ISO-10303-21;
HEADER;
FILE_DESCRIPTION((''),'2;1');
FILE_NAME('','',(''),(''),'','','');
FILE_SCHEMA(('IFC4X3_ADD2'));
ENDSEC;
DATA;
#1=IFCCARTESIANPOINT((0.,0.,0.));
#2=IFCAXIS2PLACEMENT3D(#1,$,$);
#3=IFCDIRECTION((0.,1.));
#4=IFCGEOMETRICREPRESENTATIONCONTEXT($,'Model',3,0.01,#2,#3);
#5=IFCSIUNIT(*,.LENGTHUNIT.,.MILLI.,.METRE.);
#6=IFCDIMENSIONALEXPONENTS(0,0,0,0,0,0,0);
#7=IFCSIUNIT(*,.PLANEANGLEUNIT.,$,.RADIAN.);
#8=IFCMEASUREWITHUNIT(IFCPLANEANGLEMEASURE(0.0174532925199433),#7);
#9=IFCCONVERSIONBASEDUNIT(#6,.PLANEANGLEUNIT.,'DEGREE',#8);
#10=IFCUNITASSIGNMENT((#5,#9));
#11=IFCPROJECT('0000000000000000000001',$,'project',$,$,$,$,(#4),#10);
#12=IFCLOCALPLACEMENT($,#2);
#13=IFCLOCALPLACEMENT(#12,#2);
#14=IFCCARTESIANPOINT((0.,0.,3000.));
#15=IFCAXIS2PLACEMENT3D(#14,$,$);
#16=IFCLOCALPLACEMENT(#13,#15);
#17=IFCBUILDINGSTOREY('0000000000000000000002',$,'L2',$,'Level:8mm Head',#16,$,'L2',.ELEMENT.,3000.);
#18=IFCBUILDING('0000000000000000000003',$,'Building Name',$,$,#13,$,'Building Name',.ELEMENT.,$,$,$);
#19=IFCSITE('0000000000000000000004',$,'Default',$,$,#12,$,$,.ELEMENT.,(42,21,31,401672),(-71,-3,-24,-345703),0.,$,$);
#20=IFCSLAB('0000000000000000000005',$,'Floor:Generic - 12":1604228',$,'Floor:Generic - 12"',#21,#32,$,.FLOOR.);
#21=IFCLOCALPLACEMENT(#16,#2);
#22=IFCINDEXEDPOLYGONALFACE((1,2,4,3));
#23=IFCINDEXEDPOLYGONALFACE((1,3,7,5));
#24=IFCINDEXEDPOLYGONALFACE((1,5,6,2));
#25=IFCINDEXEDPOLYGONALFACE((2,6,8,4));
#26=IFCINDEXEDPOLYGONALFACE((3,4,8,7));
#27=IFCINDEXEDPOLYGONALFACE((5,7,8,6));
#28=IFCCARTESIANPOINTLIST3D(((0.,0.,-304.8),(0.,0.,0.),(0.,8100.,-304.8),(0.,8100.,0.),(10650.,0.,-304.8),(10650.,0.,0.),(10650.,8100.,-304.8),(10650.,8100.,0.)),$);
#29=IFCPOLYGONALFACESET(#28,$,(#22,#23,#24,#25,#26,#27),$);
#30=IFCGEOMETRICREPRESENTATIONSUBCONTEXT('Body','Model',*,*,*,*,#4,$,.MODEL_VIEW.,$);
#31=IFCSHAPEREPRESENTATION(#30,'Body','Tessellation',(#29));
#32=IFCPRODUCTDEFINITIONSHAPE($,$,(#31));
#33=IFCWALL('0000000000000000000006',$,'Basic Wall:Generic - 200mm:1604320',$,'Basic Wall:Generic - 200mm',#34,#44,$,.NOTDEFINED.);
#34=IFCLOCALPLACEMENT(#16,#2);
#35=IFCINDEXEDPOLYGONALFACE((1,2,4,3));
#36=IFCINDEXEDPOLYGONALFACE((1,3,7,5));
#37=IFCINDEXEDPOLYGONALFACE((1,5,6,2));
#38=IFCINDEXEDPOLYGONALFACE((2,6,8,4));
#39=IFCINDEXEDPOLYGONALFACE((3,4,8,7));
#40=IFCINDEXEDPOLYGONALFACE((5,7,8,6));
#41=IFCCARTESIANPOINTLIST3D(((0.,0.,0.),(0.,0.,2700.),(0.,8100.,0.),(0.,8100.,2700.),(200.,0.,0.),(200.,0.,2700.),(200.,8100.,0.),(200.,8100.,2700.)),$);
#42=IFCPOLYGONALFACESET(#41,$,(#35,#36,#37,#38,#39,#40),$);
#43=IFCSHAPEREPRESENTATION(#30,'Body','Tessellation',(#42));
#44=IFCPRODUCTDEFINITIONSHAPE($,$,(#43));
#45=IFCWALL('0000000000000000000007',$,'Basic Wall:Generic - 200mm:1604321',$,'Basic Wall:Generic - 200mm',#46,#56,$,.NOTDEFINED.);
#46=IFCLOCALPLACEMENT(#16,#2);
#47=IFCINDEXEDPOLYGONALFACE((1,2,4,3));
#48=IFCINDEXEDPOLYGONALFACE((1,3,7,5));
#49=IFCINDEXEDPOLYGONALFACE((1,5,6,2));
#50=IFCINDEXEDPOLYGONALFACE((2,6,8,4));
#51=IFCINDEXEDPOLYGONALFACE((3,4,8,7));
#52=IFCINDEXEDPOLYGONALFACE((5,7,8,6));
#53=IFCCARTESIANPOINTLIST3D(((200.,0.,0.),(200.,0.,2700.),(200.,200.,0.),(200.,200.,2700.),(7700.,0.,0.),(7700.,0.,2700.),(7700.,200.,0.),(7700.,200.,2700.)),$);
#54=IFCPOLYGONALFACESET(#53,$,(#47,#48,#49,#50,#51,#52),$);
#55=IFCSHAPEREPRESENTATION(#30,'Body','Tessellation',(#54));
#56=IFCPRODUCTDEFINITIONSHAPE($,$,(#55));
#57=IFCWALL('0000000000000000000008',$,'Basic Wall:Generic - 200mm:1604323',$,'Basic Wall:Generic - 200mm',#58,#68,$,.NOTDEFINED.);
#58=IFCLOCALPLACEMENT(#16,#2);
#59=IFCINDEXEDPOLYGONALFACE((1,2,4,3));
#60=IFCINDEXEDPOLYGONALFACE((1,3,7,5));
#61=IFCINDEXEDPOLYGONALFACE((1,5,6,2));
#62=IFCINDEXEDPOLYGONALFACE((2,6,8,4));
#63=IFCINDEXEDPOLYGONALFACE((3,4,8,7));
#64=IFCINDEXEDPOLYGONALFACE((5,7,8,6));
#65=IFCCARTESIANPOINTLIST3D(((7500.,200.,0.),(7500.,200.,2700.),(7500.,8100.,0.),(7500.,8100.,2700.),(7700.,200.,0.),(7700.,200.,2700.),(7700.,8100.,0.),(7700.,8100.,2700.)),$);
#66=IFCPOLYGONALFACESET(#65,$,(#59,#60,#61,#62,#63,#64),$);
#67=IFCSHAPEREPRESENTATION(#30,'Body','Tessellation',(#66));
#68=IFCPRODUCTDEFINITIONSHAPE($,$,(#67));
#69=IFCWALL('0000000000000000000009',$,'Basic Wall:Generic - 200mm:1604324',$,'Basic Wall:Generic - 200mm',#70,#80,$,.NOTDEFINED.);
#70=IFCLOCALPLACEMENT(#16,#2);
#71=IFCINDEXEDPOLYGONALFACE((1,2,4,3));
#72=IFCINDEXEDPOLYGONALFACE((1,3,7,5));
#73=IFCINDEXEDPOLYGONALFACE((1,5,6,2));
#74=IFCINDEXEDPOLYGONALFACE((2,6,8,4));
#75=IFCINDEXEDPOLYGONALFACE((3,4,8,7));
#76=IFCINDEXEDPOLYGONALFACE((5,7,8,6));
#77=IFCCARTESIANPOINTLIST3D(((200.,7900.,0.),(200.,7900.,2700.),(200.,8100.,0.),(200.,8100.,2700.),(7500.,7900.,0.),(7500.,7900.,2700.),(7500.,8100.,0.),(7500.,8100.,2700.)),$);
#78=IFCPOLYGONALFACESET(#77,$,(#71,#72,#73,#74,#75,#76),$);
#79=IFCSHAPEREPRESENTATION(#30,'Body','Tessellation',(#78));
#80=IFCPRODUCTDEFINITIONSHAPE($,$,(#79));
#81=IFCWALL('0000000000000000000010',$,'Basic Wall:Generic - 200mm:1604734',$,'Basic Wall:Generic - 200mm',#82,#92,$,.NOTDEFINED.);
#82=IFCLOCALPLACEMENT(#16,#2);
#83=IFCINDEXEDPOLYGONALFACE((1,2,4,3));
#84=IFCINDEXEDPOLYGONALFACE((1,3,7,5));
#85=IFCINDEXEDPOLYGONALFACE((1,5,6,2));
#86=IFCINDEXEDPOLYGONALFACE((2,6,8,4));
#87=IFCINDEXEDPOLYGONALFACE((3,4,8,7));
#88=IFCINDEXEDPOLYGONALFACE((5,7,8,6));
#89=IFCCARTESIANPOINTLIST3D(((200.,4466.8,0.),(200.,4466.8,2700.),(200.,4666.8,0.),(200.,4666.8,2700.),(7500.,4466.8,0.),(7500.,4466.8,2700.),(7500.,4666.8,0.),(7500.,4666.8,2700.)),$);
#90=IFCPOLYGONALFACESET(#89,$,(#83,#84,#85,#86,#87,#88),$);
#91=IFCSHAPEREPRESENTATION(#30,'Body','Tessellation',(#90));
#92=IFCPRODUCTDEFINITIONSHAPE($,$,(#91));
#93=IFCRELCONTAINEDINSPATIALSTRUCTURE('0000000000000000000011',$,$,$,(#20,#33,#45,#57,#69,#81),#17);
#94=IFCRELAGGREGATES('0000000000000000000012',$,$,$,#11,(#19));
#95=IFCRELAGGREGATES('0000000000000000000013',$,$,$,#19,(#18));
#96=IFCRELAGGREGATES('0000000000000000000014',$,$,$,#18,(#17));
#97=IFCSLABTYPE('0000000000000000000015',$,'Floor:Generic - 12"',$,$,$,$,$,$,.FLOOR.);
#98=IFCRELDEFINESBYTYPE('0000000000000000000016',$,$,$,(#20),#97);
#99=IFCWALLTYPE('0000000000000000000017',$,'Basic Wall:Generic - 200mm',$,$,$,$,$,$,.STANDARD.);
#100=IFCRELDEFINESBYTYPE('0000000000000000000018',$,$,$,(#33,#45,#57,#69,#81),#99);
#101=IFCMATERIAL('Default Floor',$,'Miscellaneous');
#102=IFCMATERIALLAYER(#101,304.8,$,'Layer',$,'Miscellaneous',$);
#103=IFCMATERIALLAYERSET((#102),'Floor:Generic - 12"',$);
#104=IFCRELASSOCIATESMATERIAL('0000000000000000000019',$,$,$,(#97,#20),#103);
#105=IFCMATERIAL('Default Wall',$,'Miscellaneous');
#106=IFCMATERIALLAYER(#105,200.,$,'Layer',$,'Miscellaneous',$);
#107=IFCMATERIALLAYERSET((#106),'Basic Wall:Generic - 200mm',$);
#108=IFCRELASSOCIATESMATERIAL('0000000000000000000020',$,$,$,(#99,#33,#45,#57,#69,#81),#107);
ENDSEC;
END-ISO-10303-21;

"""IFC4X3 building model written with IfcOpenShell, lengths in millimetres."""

from ifc_helpers import new_model, entity, si_unit, converted_unit, direction, frame, frame_2d, origin, origin_2d_with_axis, place, context, subcontext, project, spatial, rectangle, extrude, material, layer, layer_set, layer_usage, type_object, element, save


model = new_model("IFC4X3")

# Units and contexts
model_context = context("Model", 3, precision=0.01, world=origin(), true_north=direction((0.0, 1.0)))
body_context = subcontext(model_context, "Body", "Model", "MODEL_VIEW")
ifc_project = project(units=[si_unit("LENGTHUNIT", "METRE", prefix="MILLI"), converted_unit("PLANEANGLEUNIT", "DEGREE", entity("IfcPlaneAngleMeasure", 0.0174532925199433), si_unit("PLANEANGLEUNIT", "RADIAN"), dimensions=[0, 0, 0, 0, 0, 0, 0])], contexts=[model_context])

# Site, building, storey
site_placement = place(None, origin())
site = spatial("IfcSite", under=ifc_project, at=site_placement, Name="Default", CompositionType="ELEMENT", RefLatitude=(42, 21, 31, 401672), RefLongitude=(-71, -3, -24, -345703), RefElevation=0.0)
building_placement = place(site_placement, origin())
building = spatial("IfcBuilding", under=site, at=building_placement, Name="Building Name", LongName="Building Name", CompositionType="ELEMENT")
storey_placement = place(building_placement, frame((0.0, 0.0, 3000.0)))
storey = spatial("IfcBuildingStorey", under=building, at=storey_placement, Name="L2", ObjectType="Level:8mm Head", LongName="L2", CompositionType="ELEMENT", Elevation=3000.0)

# Slab
ifc_material_1 = material(Name="Default Floor", Category="Miscellaneous")
ifc_layer_1 = layer(ifc_material_1, 304.8, Name="Layer", Category="Miscellaneous")
ifc_layer_set_1 = layer_set([ifc_layer_1], Name="Floor:Generic - 12\"")
ifc_layer_usage = layer_usage(ifc_layer_set_1, "AXIS3", "POSITIVE", 0.0)
slab_type = type_object("IfcSlabType", Name="Floor:Generic - 12\"", PredefinedType="FLOOR", material=ifc_layer_set_1)
slab_placement = place(storey_placement, origin())
element("IfcSlab", 1, at=slab_placement, inside=storey, type_object=slab_type, material=ifc_layer_usage, Name="Floor:Generic - 12\":1604228", ObjectType="Floor:Generic - 12\"", PredefinedType="FLOOR", context=body_context, shape_type="SweptSolid", body=[
    extrude(rectangle(XDim=8100.0, YDim=10650.0, at=origin_2d_with_axis()), frame((5325.0, 4050.0, 0.0), z_axis=(0.0, 0.0, -1.0), x_axis=(0.0, 1.0, 0.0)), (0.0, 0.0, 1.0), 304.8),
])

# Walls
ifc_material_2 = material(Name="Default Wall", Category="Miscellaneous")
ifc_layer_2 = layer(ifc_material_2, 200.0, Name="Layer", Category="Miscellaneous")
ifc_layer_set_2 = layer_set([ifc_layer_2], Name="Basic Wall:Generic - 200mm")
wall_type = type_object("IfcWallType", Name="Basic Wall:Generic - 200mm", PredefinedType="STANDARD", material=ifc_layer_set_2)
wall_1_placement = place(storey_placement, frame((100.0, 8100.0, 0.0), z_axis=(0.0, 0.0, 1.0), x_axis=(0.0, -1.0, 0.0)))
element("IfcWall", 2, at=wall_1_placement, inside=storey, type_object=wall_type, material=ifc_layer_set_2, Name="Basic Wall:Generic - 200mm:1604320", ObjectType="Basic Wall:Generic - 200mm", PredefinedType="NOTDEFINED", context=body_context, shape_type="SweptSolid", body=[
    extrude(rectangle(XDim=8100.0, YDim=200.0, at=frame_2d((4050.0, 0.0), x_axis=(-1.0, 0.0))), origin(), (0.0, 0.0, 1.0), 2700.0),
])
wall_2_placement = place(storey_placement, frame((200.0, 100.0, 0.0)))
element("IfcWall", 3, at=wall_2_placement, inside=storey, type_object=wall_type, material=ifc_layer_set_2, Name="Basic Wall:Generic - 200mm:1604321", ObjectType="Basic Wall:Generic - 200mm", PredefinedType="NOTDEFINED", context=body_context, shape_type="SweptSolid", body=[
    extrude(rectangle(XDim=7500.0, YDim=200.0, at=frame_2d((3750.0, 0.0), x_axis=(-1.0, 0.0))), origin(), (0.0, 0.0, 1.0), 2700.0),
])
wall_3_placement = place(storey_placement, frame((7600.0, 200.0, 0.0), z_axis=(0.0, 0.0, 1.0), x_axis=(0.0, 1.0, 0.0)))
element("IfcWall", 4, at=wall_3_placement, inside=storey, type_object=wall_type, material=ifc_layer_set_2, Name="Basic Wall:Generic - 200mm:1604323", ObjectType="Basic Wall:Generic - 200mm", PredefinedType="NOTDEFINED", context=body_context, shape_type="SweptSolid", body=[
    extrude(rectangle(XDim=7900.0, YDim=200.0, at=frame_2d((3950.0, 0.0), x_axis=(-1.0, 0.0))), origin(), (0.0, 0.0, 1.0), 2700.0),
])
wall_4_placement = place(storey_placement, frame((7500.0, 8000.0, 0.0), z_axis=(0.0, 0.0, 1.0), x_axis=(-1.0, 0.0, 0.0)))
element("IfcWall", 5, at=wall_4_placement, inside=storey, type_object=wall_type, material=ifc_layer_set_2, Name="Basic Wall:Generic - 200mm:1604324", ObjectType="Basic Wall:Generic - 200mm", PredefinedType="NOTDEFINED", context=body_context, shape_type="SweptSolid", body=[
    extrude(rectangle(XDim=7300.0, YDim=200.0, at=frame_2d((3650.0, 0.0), x_axis=(-1.0, 0.0))), origin(), (0.0, 0.0, 1.0), 2700.0),
])
wall_5_placement = place(storey_placement, frame((7500.0, 4566.8, 0.0), z_axis=(0.0, 0.0, 1.0), x_axis=(-1.0, 0.0, 0.0)))
element("IfcWall", 6, at=wall_5_placement, inside=storey, type_object=wall_type, material=ifc_layer_set_2, Name="Basic Wall:Generic - 200mm:1604734", ObjectType="Basic Wall:Generic - 200mm", PredefinedType="NOTDEFINED", context=body_context, shape_type="SweptSolid", body=[
    extrude(rectangle(XDim=7300.0, YDim=200.0, at=frame_2d((3650.0, 0.0), x_axis=(-1.0, 0.0))), origin(), (0.0, 0.0, 1.0), 2700.0),
])

save(model, "model.ifc")
